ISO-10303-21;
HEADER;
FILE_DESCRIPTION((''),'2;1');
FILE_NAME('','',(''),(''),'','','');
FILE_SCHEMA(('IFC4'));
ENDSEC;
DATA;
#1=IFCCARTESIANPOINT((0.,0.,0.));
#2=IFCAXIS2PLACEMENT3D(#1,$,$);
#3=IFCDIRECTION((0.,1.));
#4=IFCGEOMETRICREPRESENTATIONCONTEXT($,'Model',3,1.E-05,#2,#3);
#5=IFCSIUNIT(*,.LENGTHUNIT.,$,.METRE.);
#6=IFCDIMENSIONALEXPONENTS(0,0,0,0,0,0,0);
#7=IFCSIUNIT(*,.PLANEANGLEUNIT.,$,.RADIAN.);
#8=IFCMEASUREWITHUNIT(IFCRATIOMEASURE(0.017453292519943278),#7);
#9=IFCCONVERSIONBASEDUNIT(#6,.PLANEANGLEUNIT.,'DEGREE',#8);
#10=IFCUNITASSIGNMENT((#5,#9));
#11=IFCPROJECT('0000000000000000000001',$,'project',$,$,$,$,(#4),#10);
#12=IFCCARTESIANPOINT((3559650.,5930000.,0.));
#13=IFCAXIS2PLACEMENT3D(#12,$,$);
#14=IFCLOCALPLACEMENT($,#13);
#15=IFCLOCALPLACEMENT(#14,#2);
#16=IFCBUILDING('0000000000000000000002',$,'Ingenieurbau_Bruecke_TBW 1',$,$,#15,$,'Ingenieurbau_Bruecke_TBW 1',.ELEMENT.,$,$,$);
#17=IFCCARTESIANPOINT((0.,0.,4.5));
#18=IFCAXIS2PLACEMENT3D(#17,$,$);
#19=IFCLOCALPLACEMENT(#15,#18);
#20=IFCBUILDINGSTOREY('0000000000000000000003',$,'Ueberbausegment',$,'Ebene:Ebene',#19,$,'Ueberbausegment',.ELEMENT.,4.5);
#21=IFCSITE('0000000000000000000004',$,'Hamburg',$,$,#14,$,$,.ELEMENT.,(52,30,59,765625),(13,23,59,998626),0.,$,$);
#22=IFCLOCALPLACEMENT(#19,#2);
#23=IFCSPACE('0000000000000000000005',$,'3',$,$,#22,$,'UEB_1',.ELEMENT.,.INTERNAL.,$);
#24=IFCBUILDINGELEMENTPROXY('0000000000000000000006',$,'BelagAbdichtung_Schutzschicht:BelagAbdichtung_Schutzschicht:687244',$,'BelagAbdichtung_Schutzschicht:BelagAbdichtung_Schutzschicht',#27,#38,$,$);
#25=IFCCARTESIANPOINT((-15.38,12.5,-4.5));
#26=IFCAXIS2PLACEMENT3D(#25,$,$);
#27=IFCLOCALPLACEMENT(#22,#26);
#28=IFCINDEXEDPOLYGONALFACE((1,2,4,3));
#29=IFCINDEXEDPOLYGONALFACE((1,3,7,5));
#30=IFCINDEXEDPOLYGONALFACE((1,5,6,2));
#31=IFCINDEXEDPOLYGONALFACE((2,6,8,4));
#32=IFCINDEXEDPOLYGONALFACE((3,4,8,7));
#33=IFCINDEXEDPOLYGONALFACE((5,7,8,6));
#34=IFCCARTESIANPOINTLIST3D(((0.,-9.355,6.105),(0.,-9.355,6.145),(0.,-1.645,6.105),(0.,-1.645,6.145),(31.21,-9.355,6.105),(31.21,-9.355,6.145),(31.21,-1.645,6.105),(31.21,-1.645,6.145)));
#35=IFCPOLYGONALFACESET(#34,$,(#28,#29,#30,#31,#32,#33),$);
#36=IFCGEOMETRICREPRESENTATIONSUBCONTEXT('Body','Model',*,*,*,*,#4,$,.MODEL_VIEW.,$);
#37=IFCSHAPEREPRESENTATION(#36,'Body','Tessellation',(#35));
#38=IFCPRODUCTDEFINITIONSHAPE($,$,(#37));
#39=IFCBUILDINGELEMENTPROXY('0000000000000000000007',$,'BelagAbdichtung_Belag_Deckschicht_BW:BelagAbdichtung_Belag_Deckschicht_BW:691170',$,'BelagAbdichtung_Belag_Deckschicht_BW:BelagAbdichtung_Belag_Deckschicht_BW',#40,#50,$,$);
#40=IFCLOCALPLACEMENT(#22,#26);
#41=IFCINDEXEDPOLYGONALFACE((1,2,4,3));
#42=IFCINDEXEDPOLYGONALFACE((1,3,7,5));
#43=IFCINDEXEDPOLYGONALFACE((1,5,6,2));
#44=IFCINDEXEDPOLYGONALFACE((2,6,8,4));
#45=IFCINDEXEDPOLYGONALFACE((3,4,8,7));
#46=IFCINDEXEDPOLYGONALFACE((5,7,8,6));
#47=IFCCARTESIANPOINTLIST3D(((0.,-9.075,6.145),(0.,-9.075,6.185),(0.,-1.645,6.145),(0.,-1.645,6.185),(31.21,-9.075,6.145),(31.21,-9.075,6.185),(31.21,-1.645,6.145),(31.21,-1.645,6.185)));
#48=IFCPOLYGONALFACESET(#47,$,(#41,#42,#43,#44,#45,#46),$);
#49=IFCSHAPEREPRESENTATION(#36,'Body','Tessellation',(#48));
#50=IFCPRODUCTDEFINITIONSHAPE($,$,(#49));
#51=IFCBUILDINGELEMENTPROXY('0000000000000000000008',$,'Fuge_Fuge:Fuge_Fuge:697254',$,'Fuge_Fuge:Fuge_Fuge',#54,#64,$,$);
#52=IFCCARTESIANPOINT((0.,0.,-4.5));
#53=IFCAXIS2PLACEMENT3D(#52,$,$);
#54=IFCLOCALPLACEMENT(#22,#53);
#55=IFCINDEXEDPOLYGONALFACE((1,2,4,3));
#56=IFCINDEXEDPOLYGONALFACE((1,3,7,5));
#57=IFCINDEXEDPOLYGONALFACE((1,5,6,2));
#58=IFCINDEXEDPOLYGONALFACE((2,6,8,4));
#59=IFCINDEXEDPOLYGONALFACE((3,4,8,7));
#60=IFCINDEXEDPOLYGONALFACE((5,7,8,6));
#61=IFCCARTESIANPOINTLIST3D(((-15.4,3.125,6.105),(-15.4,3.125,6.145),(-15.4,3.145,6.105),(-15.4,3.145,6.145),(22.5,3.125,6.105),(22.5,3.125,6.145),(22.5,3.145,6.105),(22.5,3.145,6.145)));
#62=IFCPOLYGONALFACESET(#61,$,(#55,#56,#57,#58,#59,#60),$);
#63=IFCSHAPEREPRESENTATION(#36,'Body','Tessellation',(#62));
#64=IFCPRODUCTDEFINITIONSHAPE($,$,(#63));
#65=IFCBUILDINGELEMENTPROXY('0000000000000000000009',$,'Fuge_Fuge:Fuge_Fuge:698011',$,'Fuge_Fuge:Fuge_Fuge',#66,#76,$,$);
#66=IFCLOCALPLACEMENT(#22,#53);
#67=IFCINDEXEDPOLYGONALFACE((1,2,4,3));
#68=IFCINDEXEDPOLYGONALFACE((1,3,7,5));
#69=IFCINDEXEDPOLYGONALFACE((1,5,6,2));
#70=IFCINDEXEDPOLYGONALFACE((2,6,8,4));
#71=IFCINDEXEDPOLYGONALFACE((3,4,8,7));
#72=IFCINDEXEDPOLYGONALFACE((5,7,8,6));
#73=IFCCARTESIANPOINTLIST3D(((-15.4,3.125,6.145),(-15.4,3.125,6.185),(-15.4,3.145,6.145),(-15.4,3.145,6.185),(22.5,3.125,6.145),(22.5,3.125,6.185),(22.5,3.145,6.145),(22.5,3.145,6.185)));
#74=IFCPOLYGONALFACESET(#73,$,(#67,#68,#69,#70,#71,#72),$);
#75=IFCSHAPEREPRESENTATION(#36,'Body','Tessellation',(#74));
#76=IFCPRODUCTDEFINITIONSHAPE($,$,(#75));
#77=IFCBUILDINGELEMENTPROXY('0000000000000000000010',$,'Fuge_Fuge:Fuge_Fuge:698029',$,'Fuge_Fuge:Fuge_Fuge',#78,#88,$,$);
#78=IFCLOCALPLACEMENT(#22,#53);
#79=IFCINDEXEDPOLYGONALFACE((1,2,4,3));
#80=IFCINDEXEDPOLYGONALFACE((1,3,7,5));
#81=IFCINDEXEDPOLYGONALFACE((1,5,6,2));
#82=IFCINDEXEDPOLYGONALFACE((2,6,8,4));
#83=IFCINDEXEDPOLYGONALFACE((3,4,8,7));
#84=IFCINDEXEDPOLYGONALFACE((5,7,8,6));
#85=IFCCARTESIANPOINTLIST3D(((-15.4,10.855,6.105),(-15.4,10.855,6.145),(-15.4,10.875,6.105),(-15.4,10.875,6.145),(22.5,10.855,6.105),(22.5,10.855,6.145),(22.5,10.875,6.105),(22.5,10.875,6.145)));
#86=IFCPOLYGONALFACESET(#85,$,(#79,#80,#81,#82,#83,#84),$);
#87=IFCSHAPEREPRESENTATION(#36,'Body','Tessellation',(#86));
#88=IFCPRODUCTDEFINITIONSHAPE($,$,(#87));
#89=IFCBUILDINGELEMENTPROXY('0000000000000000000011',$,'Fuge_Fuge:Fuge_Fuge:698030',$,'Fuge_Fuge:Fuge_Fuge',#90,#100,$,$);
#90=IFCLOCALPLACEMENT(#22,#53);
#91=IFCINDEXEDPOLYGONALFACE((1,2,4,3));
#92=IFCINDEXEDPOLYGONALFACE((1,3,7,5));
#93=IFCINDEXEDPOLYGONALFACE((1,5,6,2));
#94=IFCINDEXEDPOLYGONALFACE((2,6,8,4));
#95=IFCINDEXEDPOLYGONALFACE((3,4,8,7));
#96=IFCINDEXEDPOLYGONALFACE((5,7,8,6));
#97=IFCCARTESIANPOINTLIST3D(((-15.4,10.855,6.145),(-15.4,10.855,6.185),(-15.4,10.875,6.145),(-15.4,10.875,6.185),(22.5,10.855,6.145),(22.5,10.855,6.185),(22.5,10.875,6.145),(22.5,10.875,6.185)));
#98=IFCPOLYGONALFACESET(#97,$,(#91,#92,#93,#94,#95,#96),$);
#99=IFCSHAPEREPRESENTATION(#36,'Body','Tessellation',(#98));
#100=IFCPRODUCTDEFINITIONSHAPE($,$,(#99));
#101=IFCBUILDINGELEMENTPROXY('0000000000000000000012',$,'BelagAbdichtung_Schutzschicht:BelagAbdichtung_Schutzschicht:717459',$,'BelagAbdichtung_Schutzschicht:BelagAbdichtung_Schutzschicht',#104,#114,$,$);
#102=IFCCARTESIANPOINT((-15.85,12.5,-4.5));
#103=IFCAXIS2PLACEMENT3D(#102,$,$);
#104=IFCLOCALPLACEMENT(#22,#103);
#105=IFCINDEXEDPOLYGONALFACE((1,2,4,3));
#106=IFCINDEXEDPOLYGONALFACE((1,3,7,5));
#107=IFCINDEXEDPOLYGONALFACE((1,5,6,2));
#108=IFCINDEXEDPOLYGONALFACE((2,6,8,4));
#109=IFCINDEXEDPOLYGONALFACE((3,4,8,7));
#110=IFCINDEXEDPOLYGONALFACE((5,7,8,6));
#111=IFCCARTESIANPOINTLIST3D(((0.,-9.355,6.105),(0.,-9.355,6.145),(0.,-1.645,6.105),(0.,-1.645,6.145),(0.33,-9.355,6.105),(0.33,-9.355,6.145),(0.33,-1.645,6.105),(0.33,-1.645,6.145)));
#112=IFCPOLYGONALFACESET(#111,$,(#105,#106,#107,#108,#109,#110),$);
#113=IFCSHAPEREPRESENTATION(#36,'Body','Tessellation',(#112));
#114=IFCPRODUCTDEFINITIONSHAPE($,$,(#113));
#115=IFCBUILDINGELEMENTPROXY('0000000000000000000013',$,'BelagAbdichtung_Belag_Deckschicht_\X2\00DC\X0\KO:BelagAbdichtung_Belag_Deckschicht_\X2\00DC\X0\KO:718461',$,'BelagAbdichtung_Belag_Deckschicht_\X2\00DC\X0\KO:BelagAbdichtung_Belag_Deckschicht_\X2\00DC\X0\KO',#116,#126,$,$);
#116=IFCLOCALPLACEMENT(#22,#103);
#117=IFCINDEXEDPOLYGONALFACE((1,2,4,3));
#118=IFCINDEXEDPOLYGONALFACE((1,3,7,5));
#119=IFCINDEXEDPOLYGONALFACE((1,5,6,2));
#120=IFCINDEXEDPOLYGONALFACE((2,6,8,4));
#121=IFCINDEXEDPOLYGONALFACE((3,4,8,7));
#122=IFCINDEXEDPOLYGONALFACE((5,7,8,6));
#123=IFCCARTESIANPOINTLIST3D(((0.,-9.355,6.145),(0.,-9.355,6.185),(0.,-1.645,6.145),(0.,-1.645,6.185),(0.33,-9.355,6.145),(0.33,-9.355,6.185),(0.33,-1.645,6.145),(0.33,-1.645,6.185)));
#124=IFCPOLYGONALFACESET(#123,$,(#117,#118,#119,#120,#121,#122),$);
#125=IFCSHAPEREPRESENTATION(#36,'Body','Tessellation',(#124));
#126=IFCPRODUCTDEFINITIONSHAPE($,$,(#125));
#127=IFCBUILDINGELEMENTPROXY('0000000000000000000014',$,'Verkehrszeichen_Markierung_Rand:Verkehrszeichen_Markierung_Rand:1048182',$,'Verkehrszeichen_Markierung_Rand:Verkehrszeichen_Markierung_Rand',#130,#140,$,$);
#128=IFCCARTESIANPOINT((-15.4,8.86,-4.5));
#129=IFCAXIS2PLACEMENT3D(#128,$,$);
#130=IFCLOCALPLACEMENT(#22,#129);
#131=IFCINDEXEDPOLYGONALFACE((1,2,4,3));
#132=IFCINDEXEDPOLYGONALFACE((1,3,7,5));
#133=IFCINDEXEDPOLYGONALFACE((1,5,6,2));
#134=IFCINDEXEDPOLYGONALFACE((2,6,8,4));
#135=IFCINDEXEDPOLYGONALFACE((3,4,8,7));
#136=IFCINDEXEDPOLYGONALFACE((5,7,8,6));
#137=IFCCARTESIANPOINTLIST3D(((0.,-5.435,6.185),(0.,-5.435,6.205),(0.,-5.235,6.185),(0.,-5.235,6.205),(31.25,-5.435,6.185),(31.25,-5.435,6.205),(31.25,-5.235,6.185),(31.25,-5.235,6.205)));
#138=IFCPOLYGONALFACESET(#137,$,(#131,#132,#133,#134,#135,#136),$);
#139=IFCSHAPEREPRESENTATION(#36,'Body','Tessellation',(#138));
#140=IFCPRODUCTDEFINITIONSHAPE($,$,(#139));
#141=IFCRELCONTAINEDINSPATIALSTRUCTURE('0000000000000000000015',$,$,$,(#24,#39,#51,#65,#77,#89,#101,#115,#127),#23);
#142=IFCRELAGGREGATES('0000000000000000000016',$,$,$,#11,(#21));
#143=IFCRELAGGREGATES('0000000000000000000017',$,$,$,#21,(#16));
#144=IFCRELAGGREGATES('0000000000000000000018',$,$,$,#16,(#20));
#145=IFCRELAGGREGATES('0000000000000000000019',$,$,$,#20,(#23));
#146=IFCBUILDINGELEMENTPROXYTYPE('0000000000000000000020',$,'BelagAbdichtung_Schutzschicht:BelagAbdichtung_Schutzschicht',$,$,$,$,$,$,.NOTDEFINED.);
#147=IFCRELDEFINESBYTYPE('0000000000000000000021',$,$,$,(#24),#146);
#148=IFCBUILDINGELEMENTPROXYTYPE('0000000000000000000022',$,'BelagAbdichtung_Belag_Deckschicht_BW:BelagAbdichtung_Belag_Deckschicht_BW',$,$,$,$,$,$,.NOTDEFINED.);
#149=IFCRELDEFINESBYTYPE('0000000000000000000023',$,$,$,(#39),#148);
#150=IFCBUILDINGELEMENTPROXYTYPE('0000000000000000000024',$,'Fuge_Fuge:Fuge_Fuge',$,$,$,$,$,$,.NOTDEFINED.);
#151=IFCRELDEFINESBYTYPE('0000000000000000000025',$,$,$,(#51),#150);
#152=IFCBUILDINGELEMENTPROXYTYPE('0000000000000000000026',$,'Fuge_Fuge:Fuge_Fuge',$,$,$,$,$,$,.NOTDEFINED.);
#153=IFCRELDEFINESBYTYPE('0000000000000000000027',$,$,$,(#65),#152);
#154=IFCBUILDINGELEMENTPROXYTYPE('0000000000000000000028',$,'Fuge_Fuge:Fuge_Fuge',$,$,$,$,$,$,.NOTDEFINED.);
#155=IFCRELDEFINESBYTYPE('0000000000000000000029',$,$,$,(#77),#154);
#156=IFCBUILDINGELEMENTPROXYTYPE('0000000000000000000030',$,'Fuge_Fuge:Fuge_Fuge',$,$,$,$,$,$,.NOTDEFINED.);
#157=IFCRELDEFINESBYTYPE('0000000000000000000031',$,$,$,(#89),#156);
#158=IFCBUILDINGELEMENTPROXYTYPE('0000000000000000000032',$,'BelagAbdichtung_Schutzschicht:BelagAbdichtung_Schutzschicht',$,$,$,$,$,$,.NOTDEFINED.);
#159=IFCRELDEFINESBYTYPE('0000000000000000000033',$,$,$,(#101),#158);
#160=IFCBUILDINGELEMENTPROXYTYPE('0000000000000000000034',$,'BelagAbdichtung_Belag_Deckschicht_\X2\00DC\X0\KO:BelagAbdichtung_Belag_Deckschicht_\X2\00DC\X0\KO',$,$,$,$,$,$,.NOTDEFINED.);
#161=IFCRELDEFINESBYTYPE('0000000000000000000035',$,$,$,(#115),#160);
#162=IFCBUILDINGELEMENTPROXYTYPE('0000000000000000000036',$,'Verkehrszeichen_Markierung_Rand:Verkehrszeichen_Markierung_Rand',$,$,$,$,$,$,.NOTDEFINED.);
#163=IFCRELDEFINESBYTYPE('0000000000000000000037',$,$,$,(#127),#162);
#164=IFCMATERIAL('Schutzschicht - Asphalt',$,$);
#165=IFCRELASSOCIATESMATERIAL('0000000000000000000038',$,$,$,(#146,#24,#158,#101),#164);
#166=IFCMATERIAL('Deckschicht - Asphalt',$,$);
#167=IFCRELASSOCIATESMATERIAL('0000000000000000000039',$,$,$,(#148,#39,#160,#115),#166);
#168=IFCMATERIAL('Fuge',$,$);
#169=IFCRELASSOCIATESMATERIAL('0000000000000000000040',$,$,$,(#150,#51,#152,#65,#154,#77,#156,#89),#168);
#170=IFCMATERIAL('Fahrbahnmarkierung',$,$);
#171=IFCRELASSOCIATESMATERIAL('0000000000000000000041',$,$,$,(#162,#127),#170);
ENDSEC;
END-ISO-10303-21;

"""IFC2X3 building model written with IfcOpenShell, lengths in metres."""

from ifc_helpers import new_model, entity, si_unit, converted_unit, direction, frame, origin, origin_2d_with_axis, place, context, subcontext, project, spatial, rectangle, extrude, source, transform, mapped, material, type_object, type_shapes, element, save


model = new_model("IFC2X3")

# Units and contexts
model_context = context("Model", 3, precision=1e-05, world=origin(), true_north=direction((0.0, 1.0)))
body_context = subcontext(model_context, "Body", "Model", "MODEL_VIEW")
ifc_project = project(units=[si_unit("LENGTHUNIT", "METRE"), converted_unit("PLANEANGLEUNIT", "DEGREE", entity("IfcRatioMeasure", 0.017453292519943278), si_unit("PLANEANGLEUNIT", "RADIAN"), dimensions=[0, 0, 0, 0, 0, 0, 0])], contexts=[model_context])

# Site, building, storey, space
site_placement = place(None, frame((3559650.0, 5930000.0, 0.0)))
site = spatial("IfcSite", under=ifc_project, at=site_placement, Name="Hamburg", CompositionType="ELEMENT", RefLatitude=(52, 30, 59, 765625), RefLongitude=(13, 23, 59, 998626), RefElevation=0.0)
building_placement = place(site_placement, origin())
building = spatial("IfcBuilding", under=site, at=building_placement, Name="Ingenieurbau_Bruecke_TBW 1", LongName="Ingenieurbau_Bruecke_TBW 1", CompositionType="ELEMENT")
storey_placement = place(building_placement, frame((0.0, 0.0, 4.5)))
storey = spatial("IfcBuildingStorey", under=building, at=storey_placement, Name="Ueberbausegment", ObjectType="Ebene:Ebene", LongName="Ueberbausegment", CompositionType="ELEMENT", Elevation=4.5)
space_placement = place(storey_placement, origin())
space = spatial("IfcSpace", under=storey, at=space_placement, Name="3", LongName="UEB_1", CompositionType="ELEMENT", InteriorOrExteriorSpace="INTERNAL")

# Building element proxies
ifc_material_1 = material(Name="Schutzschicht - Asphalt")
building_element_proxy_type_1 = type_object("IfcBuildingElementProxyType", Name="BelagAbdichtung_Schutzschicht:BelagAbdichtung_Schutzschicht", PredefinedType="NOTDEFINED", material=ifc_material_1)
shared_shape_1 = source(origin(), body_context, "Body", "SweptSolid", [
    extrude(rectangle(XDim=31.21, YDim=7.71, at=origin_2d_with_axis()), frame((15.605, -5.5, 6.105), z_axis=(0.0, 0.0, 1.0), x_axis=(-1.0, 0.0, 0.0)), (0.0, 0.0, 1.0), 0.04),
])
type_shapes(building_element_proxy_type_1, [shared_shape_1])
proxy_1_placement = place(space_placement, frame((-15.38, 12.5, -4.5)))
element("IfcBuildingElementProxy", 1, at=proxy_1_placement, inside=space, type_object=building_element_proxy_type_1, material=ifc_material_1, Name="BelagAbdichtung_Schutzschicht:BelagAbdichtung_Schutzschicht:687244", ObjectType="BelagAbdichtung_Schutzschicht:BelagAbdichtung_Schutzschicht", context=body_context, shape_type="MappedRepresentation", body=[
    mapped(shared_shape_1, transform((0.0, 0.0, 0.0), scale=1.0)),
])
ifc_material_2 = material(Name="Deckschicht - Asphalt")
building_element_proxy_type_2 = type_object("IfcBuildingElementProxyType", Name="BelagAbdichtung_Belag_Deckschicht_BW:BelagAbdichtung_Belag_Deckschicht_BW", PredefinedType="NOTDEFINED", material=ifc_material_2)
shared_shape_2 = source(origin(), body_context, "Body", "SweptSolid", [
    extrude(rectangle(XDim=31.21, YDim=7.43, at=origin_2d_with_axis()), frame((15.605, -5.36, 6.145), z_axis=(0.0, 0.0, 1.0), x_axis=(-1.0, 0.0, 0.0)), (0.0, 0.0, 1.0), 0.04),
])
type_shapes(building_element_proxy_type_2, [shared_shape_2])
proxy_2_placement = place(space_placement, frame((-15.38, 12.5, -4.5)))
element("IfcBuildingElementProxy", 2, at=proxy_2_placement, inside=space, type_object=building_element_proxy_type_2, material=ifc_material_2, Name="BelagAbdichtung_Belag_Deckschicht_BW:BelagAbdichtung_Belag_Deckschicht_BW:691170", ObjectType="BelagAbdichtung_Belag_Deckschicht_BW:BelagAbdichtung_Belag_Deckschicht_BW", context=body_context, shape_type="MappedRepresentation", body=[
    mapped(shared_shape_2, transform((0.0, 0.0, 0.0), scale=1.0)),
])
ifc_material_3 = material(Name="Fuge")
building_element_proxy_type_3 = type_object("IfcBuildingElementProxyType", Name="Fuge_Fuge:Fuge_Fuge", PredefinedType="NOTDEFINED", material=ifc_material_3)
shared_shape_3 = source(origin(), body_context, "Body", "SweptSolid", [
    extrude(rectangle(XDim=37.9, YDim=0.02, at=origin_2d_with_axis()), frame((3.55, 3.135, 6.105), z_axis=(0.0, 0.0, 1.0), x_axis=(-1.0, 0.0, 0.0)), (0.0, 0.0, 1.0), 0.04),
])
type_shapes(building_element_proxy_type_3, [shared_shape_3])
proxy_3_placement = place(space_placement, frame((0.0, 0.0, -4.5)))
element("IfcBuildingElementProxy", 3, at=proxy_3_placement, inside=space, type_object=building_element_proxy_type_3, material=ifc_material_3, Name="Fuge_Fuge:Fuge_Fuge:697254", ObjectType="Fuge_Fuge:Fuge_Fuge", context=body_context, shape_type="MappedRepresentation", body=[
    mapped(shared_shape_3, transform((0.0, 0.0, 0.0), scale=1.0)),
])
building_element_proxy_type_4 = type_object("IfcBuildingElementProxyType", Name="Fuge_Fuge:Fuge_Fuge", PredefinedType="NOTDEFINED", material=ifc_material_3)
shared_shape_4 = source(origin(), body_context, "Body", "SweptSolid", [
    extrude(rectangle(XDim=37.9, YDim=0.02, at=origin_2d_with_axis()), frame((3.55, 3.135, 6.145), z_axis=(0.0, 0.0, 1.0), x_axis=(-1.0, 0.0, 0.0)), (0.0, 0.0, 1.0), 0.04),
])
type_shapes(building_element_proxy_type_4, [shared_shape_4])
proxy_4_placement = place(space_placement, frame((0.0, 0.0, -4.5)))
element("IfcBuildingElementProxy", 4, at=proxy_4_placement, inside=space, type_object=building_element_proxy_type_4, material=ifc_material_3, Name="Fuge_Fuge:Fuge_Fuge:698011", ObjectType="Fuge_Fuge:Fuge_Fuge", context=body_context, shape_type="MappedRepresentation", body=[
    mapped(shared_shape_4, transform((0.0, 0.0, 0.0), scale=1.0)),
])
building_element_proxy_type_5 = type_object("IfcBuildingElementProxyType", Name="Fuge_Fuge:Fuge_Fuge", PredefinedType="NOTDEFINED", material=ifc_material_3)
shared_shape_5 = source(origin(), body_context, "Body", "SweptSolid", [
    extrude(rectangle(XDim=37.9, YDim=0.02, at=origin_2d_with_axis()), frame((3.55, 10.865, 6.105), z_axis=(0.0, 0.0, 1.0), x_axis=(-1.0, 0.0, 0.0)), (0.0, 0.0, 1.0), 0.04),
])
type_shapes(building_element_proxy_type_5, [shared_shape_5])
proxy_5_placement = place(space_placement, frame((0.0, 0.0, -4.5)))
element("IfcBuildingElementProxy", 5, at=proxy_5_placement, inside=space, type_object=building_element_proxy_type_5, material=ifc_material_3, Name="Fuge_Fuge:Fuge_Fuge:698029", ObjectType="Fuge_Fuge:Fuge_Fuge", context=body_context, shape_type="MappedRepresentation", body=[
    mapped(shared_shape_5, transform((0.0, 0.0, 0.0), scale=1.0)),
])
building_element_proxy_type_6 = type_object("IfcBuildingElementProxyType", Name="Fuge_Fuge:Fuge_Fuge", PredefinedType="NOTDEFINED", material=ifc_material_3)
shared_shape_6 = source(origin(), body_context, "Body", "SweptSolid", [
    extrude(rectangle(XDim=37.9, YDim=0.02, at=origin_2d_with_axis()), frame((3.55, 10.865, 6.145), z_axis=(0.0, 0.0, 1.0), x_axis=(-1.0, 0.0, 0.0)), (0.0, 0.0, 1.0), 0.04),
])
type_shapes(building_element_proxy_type_6, [shared_shape_6])
proxy_6_placement = place(space_placement, frame((0.0, 0.0, -4.5)))
element("IfcBuildingElementProxy", 6, at=proxy_6_placement, inside=space, type_object=building_element_proxy_type_6, material=ifc_material_3, Name="Fuge_Fuge:Fuge_Fuge:698030", ObjectType="Fuge_Fuge:Fuge_Fuge", context=body_context, shape_type="MappedRepresentation", body=[
    mapped(shared_shape_6, transform((0.0, 0.0, 0.0), scale=1.0)),
])
building_element_proxy_type_7 = type_object("IfcBuildingElementProxyType", Name="BelagAbdichtung_Schutzschicht:BelagAbdichtung_Schutzschicht", PredefinedType="NOTDEFINED", material=ifc_material_1)
shared_shape_7 = source(origin(), body_context, "Body", "SweptSolid", [
    extrude(rectangle(XDim=0.33, YDim=7.71, at=origin_2d_with_axis()), frame((0.165, -5.5, 6.105), z_axis=(0.0, 0.0, 1.0), x_axis=(-1.0, 0.0, 0.0)), (0.0, 0.0, 1.0), 0.04),
])
type_shapes(building_element_proxy_type_7, [shared_shape_7])
proxy_7_placement = place(space_placement, frame((-15.85, 12.5, -4.5)))
element("IfcBuildingElementProxy", 7, at=proxy_7_placement, inside=space, type_object=building_element_proxy_type_7, material=ifc_material_1, Name="BelagAbdichtung_Schutzschicht:BelagAbdichtung_Schutzschicht:717459", ObjectType="BelagAbdichtung_Schutzschicht:BelagAbdichtung_Schutzschicht", context=body_context, shape_type="MappedRepresentation", body=[
    mapped(shared_shape_7, transform((0.0, 0.0, 0.0), scale=1.0)),
])
building_element_proxy_type_8 = type_object("IfcBuildingElementProxyType", Name="BelagAbdichtung_Belag_Deckschicht_ÜKO:BelagAbdichtung_Belag_Deckschicht_ÜKO", PredefinedType="NOTDEFINED", material=ifc_material_2)
shared_shape_8 = source(origin(), body_context, "Body", "SweptSolid", [
    extrude(rectangle(XDim=0.33, YDim=7.71, at=origin_2d_with_axis()), frame((0.165, -5.5, 6.145), z_axis=(0.0, 0.0, 1.0), x_axis=(-1.0, 0.0, 0.0)), (0.0, 0.0, 1.0), 0.04),
])
type_shapes(building_element_proxy_type_8, [shared_shape_8])
proxy_8_placement = place(space_placement, frame((-15.85, 12.5, -4.5)))
element("IfcBuildingElementProxy", 8, at=proxy_8_placement, inside=space, type_object=building_element_proxy_type_8, material=ifc_material_2, Name="BelagAbdichtung_Belag_Deckschicht_ÜKO:BelagAbdichtung_Belag_Deckschicht_ÜKO:718461", ObjectType="BelagAbdichtung_Belag_Deckschicht_ÜKO:BelagAbdichtung_Belag_Deckschicht_ÜKO", context=body_context, shape_type="MappedRepresentation", body=[
    mapped(shared_shape_8, transform((0.0, 0.0, 0.0), scale=1.0)),
])
ifc_material_4 = material(Name="Fahrbahnmarkierung")
building_element_proxy_type_9 = type_object("IfcBuildingElementProxyType", Name="Verkehrszeichen_Markierung_Rand:Verkehrszeichen_Markierung_Rand", PredefinedType="NOTDEFINED", material=ifc_material_4)
shared_shape_9 = source(origin(), body_context, "Body", "SweptSolid", [
    extrude(rectangle(XDim=31.25, YDim=0.2, at=origin_2d_with_axis()), frame((15.625, -5.335, 6.185), z_axis=(0.0, 0.0, 1.0), x_axis=(-1.0, 0.0, 0.0)), (0.0, 0.0, 1.0), 0.02),
])
type_shapes(building_element_proxy_type_9, [shared_shape_9])
proxy_9_placement = place(space_placement, frame((-15.4, 8.86, -4.5)))
element("IfcBuildingElementProxy", 9, at=proxy_9_placement, inside=space, type_object=building_element_proxy_type_9, material=ifc_material_4, Name="Verkehrszeichen_Markierung_Rand:Verkehrszeichen_Markierung_Rand:1048182", ObjectType="Verkehrszeichen_Markierung_Rand:Verkehrszeichen_Markierung_Rand", context=body_context, shape_type="MappedRepresentation", body=[
    mapped(shared_shape_9, transform((0.0, 0.0, 0.0), scale=1.0)),
])

save(model, "model.ifc")
